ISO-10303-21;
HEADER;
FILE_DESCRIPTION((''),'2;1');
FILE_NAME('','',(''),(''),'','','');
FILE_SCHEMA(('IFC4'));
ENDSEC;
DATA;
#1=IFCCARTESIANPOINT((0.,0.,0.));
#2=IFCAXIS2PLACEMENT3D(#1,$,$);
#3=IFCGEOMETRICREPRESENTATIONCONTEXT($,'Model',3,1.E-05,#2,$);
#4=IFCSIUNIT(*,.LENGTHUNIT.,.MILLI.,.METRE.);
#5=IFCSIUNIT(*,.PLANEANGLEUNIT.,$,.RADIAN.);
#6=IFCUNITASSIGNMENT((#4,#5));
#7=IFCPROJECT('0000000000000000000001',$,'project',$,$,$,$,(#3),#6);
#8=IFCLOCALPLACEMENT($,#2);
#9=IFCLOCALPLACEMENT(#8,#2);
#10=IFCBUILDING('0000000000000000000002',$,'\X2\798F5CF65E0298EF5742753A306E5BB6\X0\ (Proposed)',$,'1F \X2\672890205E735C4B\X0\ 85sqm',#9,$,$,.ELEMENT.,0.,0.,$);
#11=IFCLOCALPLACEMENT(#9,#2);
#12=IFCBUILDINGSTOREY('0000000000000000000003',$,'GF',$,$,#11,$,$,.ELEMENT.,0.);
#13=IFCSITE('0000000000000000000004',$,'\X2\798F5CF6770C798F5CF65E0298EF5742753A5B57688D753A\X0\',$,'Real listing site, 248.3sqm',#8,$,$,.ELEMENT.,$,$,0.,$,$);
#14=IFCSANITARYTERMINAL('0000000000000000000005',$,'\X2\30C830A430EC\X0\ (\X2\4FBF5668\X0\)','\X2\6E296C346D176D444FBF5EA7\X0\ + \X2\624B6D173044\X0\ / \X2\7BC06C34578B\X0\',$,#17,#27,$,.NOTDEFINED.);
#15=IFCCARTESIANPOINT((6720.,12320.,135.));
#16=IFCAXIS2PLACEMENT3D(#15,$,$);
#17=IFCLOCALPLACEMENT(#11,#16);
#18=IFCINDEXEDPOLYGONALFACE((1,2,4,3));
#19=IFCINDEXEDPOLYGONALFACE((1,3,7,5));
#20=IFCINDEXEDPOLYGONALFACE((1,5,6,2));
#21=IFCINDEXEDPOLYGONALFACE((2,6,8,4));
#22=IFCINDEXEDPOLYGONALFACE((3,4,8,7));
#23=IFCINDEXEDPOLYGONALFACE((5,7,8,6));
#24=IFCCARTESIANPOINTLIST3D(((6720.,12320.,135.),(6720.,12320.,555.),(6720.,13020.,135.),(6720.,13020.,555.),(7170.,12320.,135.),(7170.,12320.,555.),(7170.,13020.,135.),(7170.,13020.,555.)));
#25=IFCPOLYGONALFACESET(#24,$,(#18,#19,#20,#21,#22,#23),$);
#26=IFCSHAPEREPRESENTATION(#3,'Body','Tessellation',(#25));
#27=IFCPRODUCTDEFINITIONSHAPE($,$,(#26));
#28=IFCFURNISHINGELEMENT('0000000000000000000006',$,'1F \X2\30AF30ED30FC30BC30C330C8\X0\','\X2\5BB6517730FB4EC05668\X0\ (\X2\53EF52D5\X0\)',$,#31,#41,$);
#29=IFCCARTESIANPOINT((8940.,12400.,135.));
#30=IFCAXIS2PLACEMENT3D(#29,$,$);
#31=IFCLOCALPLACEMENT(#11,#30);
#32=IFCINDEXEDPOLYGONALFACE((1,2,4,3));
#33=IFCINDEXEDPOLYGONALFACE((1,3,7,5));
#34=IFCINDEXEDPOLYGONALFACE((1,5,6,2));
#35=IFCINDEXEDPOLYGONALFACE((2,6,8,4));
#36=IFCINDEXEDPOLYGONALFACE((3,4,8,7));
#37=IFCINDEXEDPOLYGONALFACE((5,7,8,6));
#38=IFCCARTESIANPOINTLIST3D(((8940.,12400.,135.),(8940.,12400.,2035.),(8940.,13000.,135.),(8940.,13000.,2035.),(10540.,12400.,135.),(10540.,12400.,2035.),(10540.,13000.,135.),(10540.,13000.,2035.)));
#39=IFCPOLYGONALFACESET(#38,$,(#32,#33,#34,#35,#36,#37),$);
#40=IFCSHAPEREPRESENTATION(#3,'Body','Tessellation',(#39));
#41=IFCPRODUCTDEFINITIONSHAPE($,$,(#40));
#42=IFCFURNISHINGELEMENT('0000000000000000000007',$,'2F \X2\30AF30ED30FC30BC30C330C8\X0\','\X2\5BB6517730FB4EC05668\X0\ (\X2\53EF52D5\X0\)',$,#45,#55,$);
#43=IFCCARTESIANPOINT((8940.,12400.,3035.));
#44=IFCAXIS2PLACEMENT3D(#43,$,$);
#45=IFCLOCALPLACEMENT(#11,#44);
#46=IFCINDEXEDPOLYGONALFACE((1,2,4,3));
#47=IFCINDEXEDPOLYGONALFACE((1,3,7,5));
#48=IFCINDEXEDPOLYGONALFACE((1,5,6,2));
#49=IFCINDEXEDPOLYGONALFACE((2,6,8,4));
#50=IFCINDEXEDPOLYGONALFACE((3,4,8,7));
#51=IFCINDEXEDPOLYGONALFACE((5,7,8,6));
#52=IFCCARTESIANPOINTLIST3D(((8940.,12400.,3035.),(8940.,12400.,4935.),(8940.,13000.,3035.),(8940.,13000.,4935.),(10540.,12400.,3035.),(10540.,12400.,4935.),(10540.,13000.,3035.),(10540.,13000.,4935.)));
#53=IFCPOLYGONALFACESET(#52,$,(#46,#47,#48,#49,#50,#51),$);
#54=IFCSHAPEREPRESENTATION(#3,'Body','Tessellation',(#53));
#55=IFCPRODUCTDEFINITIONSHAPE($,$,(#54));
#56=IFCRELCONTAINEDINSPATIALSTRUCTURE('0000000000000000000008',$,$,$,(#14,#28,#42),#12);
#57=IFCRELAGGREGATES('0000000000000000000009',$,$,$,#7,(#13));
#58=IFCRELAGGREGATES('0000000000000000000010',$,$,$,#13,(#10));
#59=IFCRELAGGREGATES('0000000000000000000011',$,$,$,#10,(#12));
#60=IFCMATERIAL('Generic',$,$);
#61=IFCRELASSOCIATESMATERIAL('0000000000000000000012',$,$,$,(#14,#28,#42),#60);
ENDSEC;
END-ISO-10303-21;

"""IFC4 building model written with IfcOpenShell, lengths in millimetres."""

from ifc_helpers import new_model, si_unit, frame, frame_2d, origin, place, context, project, spatial, rectangle, extrude, material, element, save


model = new_model("IFC4")

# Units and contexts
model_context = context("Model", 3, precision=1e-05, world=origin())
ifc_project = project(units=[si_unit("LENGTHUNIT", "METRE", prefix="MILLI"), si_unit("PLANEANGLEUNIT", "RADIAN")], contexts=[model_context])

# Site, building, storey
site_placement = place(None, origin())
site = spatial("IfcSite", under=ifc_project, at=site_placement, Name="福島県福島市飯坂町字梍町", ObjectType="Real listing site, 248.3sqm", CompositionType="ELEMENT", RefElevation=0.0)
building_placement = place(site_placement, origin())
building = spatial("IfcBuilding", under=site, at=building_placement, Name="福島市飯坂町の家 (Proposed)", ObjectType="1F 木造平屋 85sqm", CompositionType="ELEMENT", ElevationOfRefHeight=0.0, ElevationOfTerrain=0.0)
storey_placement = place(building_placement, origin())
storey = spatial("IfcBuildingStorey", under=building, at=storey_placement, Name="GF", CompositionType="ELEMENT", Elevation=0.0)

# Sanitary terminal
ifc_material_1 = material(Name="Generic")
sanitary_terminal_1_placement = place(storey_placement, frame((6720.0, 12320.0, 135.0)))
element("IfcSanitaryTerminal", 1, at=sanitary_terminal_1_placement, inside=storey, material=ifc_material_1, Name="トイレ (便器)", Description="温水洗浄便座 + 手洗い / 節水型", PredefinedType="NOTDEFINED", context=model_context, shape_type="SweptSolid", body=[
    extrude(rectangle(XDim=450.0, YDim=700.0, at=frame_2d((225.0, 350.0))), frame((6720.0, 12320.0, 135.0)), (0.0, 0.0, 1.0), 420.0),
])

# Furnishing elements
furnishing_1_placement = place(storey_placement, frame((8940.0, 12400.0, 135.0)))
element("IfcFurnishingElement", 2, at=furnishing_1_placement, inside=storey, material=ifc_material_1, Name="1F クローゼット", Description="家具・什器 (可動)", context=model_context, shape_type="SweptSolid", body=[
    extrude(rectangle(XDim=1600.0, YDim=600.0, at=frame_2d((800.0, 300.0))), frame((8940.0, 12400.0, 135.0)), (0.0, 0.0, 1.0), 1900.0),
])
furnishing_2_placement = place(storey_placement, frame((8940.0, 12400.0, 3035.0)))
element("IfcFurnishingElement", 3, at=furnishing_2_placement, inside=storey, material=ifc_material_1, Name="2F クローゼット", Description="家具・什器 (可動)", context=model_context, shape_type="SweptSolid", body=[
    extrude(rectangle(XDim=1600.0, YDim=600.0, at=frame_2d((800.0, 300.0))), frame((8940.0, 12400.0, 3035.0)), (0.0, 0.0, 1.0), 1900.0),
])

save(model, "model.ifc")
